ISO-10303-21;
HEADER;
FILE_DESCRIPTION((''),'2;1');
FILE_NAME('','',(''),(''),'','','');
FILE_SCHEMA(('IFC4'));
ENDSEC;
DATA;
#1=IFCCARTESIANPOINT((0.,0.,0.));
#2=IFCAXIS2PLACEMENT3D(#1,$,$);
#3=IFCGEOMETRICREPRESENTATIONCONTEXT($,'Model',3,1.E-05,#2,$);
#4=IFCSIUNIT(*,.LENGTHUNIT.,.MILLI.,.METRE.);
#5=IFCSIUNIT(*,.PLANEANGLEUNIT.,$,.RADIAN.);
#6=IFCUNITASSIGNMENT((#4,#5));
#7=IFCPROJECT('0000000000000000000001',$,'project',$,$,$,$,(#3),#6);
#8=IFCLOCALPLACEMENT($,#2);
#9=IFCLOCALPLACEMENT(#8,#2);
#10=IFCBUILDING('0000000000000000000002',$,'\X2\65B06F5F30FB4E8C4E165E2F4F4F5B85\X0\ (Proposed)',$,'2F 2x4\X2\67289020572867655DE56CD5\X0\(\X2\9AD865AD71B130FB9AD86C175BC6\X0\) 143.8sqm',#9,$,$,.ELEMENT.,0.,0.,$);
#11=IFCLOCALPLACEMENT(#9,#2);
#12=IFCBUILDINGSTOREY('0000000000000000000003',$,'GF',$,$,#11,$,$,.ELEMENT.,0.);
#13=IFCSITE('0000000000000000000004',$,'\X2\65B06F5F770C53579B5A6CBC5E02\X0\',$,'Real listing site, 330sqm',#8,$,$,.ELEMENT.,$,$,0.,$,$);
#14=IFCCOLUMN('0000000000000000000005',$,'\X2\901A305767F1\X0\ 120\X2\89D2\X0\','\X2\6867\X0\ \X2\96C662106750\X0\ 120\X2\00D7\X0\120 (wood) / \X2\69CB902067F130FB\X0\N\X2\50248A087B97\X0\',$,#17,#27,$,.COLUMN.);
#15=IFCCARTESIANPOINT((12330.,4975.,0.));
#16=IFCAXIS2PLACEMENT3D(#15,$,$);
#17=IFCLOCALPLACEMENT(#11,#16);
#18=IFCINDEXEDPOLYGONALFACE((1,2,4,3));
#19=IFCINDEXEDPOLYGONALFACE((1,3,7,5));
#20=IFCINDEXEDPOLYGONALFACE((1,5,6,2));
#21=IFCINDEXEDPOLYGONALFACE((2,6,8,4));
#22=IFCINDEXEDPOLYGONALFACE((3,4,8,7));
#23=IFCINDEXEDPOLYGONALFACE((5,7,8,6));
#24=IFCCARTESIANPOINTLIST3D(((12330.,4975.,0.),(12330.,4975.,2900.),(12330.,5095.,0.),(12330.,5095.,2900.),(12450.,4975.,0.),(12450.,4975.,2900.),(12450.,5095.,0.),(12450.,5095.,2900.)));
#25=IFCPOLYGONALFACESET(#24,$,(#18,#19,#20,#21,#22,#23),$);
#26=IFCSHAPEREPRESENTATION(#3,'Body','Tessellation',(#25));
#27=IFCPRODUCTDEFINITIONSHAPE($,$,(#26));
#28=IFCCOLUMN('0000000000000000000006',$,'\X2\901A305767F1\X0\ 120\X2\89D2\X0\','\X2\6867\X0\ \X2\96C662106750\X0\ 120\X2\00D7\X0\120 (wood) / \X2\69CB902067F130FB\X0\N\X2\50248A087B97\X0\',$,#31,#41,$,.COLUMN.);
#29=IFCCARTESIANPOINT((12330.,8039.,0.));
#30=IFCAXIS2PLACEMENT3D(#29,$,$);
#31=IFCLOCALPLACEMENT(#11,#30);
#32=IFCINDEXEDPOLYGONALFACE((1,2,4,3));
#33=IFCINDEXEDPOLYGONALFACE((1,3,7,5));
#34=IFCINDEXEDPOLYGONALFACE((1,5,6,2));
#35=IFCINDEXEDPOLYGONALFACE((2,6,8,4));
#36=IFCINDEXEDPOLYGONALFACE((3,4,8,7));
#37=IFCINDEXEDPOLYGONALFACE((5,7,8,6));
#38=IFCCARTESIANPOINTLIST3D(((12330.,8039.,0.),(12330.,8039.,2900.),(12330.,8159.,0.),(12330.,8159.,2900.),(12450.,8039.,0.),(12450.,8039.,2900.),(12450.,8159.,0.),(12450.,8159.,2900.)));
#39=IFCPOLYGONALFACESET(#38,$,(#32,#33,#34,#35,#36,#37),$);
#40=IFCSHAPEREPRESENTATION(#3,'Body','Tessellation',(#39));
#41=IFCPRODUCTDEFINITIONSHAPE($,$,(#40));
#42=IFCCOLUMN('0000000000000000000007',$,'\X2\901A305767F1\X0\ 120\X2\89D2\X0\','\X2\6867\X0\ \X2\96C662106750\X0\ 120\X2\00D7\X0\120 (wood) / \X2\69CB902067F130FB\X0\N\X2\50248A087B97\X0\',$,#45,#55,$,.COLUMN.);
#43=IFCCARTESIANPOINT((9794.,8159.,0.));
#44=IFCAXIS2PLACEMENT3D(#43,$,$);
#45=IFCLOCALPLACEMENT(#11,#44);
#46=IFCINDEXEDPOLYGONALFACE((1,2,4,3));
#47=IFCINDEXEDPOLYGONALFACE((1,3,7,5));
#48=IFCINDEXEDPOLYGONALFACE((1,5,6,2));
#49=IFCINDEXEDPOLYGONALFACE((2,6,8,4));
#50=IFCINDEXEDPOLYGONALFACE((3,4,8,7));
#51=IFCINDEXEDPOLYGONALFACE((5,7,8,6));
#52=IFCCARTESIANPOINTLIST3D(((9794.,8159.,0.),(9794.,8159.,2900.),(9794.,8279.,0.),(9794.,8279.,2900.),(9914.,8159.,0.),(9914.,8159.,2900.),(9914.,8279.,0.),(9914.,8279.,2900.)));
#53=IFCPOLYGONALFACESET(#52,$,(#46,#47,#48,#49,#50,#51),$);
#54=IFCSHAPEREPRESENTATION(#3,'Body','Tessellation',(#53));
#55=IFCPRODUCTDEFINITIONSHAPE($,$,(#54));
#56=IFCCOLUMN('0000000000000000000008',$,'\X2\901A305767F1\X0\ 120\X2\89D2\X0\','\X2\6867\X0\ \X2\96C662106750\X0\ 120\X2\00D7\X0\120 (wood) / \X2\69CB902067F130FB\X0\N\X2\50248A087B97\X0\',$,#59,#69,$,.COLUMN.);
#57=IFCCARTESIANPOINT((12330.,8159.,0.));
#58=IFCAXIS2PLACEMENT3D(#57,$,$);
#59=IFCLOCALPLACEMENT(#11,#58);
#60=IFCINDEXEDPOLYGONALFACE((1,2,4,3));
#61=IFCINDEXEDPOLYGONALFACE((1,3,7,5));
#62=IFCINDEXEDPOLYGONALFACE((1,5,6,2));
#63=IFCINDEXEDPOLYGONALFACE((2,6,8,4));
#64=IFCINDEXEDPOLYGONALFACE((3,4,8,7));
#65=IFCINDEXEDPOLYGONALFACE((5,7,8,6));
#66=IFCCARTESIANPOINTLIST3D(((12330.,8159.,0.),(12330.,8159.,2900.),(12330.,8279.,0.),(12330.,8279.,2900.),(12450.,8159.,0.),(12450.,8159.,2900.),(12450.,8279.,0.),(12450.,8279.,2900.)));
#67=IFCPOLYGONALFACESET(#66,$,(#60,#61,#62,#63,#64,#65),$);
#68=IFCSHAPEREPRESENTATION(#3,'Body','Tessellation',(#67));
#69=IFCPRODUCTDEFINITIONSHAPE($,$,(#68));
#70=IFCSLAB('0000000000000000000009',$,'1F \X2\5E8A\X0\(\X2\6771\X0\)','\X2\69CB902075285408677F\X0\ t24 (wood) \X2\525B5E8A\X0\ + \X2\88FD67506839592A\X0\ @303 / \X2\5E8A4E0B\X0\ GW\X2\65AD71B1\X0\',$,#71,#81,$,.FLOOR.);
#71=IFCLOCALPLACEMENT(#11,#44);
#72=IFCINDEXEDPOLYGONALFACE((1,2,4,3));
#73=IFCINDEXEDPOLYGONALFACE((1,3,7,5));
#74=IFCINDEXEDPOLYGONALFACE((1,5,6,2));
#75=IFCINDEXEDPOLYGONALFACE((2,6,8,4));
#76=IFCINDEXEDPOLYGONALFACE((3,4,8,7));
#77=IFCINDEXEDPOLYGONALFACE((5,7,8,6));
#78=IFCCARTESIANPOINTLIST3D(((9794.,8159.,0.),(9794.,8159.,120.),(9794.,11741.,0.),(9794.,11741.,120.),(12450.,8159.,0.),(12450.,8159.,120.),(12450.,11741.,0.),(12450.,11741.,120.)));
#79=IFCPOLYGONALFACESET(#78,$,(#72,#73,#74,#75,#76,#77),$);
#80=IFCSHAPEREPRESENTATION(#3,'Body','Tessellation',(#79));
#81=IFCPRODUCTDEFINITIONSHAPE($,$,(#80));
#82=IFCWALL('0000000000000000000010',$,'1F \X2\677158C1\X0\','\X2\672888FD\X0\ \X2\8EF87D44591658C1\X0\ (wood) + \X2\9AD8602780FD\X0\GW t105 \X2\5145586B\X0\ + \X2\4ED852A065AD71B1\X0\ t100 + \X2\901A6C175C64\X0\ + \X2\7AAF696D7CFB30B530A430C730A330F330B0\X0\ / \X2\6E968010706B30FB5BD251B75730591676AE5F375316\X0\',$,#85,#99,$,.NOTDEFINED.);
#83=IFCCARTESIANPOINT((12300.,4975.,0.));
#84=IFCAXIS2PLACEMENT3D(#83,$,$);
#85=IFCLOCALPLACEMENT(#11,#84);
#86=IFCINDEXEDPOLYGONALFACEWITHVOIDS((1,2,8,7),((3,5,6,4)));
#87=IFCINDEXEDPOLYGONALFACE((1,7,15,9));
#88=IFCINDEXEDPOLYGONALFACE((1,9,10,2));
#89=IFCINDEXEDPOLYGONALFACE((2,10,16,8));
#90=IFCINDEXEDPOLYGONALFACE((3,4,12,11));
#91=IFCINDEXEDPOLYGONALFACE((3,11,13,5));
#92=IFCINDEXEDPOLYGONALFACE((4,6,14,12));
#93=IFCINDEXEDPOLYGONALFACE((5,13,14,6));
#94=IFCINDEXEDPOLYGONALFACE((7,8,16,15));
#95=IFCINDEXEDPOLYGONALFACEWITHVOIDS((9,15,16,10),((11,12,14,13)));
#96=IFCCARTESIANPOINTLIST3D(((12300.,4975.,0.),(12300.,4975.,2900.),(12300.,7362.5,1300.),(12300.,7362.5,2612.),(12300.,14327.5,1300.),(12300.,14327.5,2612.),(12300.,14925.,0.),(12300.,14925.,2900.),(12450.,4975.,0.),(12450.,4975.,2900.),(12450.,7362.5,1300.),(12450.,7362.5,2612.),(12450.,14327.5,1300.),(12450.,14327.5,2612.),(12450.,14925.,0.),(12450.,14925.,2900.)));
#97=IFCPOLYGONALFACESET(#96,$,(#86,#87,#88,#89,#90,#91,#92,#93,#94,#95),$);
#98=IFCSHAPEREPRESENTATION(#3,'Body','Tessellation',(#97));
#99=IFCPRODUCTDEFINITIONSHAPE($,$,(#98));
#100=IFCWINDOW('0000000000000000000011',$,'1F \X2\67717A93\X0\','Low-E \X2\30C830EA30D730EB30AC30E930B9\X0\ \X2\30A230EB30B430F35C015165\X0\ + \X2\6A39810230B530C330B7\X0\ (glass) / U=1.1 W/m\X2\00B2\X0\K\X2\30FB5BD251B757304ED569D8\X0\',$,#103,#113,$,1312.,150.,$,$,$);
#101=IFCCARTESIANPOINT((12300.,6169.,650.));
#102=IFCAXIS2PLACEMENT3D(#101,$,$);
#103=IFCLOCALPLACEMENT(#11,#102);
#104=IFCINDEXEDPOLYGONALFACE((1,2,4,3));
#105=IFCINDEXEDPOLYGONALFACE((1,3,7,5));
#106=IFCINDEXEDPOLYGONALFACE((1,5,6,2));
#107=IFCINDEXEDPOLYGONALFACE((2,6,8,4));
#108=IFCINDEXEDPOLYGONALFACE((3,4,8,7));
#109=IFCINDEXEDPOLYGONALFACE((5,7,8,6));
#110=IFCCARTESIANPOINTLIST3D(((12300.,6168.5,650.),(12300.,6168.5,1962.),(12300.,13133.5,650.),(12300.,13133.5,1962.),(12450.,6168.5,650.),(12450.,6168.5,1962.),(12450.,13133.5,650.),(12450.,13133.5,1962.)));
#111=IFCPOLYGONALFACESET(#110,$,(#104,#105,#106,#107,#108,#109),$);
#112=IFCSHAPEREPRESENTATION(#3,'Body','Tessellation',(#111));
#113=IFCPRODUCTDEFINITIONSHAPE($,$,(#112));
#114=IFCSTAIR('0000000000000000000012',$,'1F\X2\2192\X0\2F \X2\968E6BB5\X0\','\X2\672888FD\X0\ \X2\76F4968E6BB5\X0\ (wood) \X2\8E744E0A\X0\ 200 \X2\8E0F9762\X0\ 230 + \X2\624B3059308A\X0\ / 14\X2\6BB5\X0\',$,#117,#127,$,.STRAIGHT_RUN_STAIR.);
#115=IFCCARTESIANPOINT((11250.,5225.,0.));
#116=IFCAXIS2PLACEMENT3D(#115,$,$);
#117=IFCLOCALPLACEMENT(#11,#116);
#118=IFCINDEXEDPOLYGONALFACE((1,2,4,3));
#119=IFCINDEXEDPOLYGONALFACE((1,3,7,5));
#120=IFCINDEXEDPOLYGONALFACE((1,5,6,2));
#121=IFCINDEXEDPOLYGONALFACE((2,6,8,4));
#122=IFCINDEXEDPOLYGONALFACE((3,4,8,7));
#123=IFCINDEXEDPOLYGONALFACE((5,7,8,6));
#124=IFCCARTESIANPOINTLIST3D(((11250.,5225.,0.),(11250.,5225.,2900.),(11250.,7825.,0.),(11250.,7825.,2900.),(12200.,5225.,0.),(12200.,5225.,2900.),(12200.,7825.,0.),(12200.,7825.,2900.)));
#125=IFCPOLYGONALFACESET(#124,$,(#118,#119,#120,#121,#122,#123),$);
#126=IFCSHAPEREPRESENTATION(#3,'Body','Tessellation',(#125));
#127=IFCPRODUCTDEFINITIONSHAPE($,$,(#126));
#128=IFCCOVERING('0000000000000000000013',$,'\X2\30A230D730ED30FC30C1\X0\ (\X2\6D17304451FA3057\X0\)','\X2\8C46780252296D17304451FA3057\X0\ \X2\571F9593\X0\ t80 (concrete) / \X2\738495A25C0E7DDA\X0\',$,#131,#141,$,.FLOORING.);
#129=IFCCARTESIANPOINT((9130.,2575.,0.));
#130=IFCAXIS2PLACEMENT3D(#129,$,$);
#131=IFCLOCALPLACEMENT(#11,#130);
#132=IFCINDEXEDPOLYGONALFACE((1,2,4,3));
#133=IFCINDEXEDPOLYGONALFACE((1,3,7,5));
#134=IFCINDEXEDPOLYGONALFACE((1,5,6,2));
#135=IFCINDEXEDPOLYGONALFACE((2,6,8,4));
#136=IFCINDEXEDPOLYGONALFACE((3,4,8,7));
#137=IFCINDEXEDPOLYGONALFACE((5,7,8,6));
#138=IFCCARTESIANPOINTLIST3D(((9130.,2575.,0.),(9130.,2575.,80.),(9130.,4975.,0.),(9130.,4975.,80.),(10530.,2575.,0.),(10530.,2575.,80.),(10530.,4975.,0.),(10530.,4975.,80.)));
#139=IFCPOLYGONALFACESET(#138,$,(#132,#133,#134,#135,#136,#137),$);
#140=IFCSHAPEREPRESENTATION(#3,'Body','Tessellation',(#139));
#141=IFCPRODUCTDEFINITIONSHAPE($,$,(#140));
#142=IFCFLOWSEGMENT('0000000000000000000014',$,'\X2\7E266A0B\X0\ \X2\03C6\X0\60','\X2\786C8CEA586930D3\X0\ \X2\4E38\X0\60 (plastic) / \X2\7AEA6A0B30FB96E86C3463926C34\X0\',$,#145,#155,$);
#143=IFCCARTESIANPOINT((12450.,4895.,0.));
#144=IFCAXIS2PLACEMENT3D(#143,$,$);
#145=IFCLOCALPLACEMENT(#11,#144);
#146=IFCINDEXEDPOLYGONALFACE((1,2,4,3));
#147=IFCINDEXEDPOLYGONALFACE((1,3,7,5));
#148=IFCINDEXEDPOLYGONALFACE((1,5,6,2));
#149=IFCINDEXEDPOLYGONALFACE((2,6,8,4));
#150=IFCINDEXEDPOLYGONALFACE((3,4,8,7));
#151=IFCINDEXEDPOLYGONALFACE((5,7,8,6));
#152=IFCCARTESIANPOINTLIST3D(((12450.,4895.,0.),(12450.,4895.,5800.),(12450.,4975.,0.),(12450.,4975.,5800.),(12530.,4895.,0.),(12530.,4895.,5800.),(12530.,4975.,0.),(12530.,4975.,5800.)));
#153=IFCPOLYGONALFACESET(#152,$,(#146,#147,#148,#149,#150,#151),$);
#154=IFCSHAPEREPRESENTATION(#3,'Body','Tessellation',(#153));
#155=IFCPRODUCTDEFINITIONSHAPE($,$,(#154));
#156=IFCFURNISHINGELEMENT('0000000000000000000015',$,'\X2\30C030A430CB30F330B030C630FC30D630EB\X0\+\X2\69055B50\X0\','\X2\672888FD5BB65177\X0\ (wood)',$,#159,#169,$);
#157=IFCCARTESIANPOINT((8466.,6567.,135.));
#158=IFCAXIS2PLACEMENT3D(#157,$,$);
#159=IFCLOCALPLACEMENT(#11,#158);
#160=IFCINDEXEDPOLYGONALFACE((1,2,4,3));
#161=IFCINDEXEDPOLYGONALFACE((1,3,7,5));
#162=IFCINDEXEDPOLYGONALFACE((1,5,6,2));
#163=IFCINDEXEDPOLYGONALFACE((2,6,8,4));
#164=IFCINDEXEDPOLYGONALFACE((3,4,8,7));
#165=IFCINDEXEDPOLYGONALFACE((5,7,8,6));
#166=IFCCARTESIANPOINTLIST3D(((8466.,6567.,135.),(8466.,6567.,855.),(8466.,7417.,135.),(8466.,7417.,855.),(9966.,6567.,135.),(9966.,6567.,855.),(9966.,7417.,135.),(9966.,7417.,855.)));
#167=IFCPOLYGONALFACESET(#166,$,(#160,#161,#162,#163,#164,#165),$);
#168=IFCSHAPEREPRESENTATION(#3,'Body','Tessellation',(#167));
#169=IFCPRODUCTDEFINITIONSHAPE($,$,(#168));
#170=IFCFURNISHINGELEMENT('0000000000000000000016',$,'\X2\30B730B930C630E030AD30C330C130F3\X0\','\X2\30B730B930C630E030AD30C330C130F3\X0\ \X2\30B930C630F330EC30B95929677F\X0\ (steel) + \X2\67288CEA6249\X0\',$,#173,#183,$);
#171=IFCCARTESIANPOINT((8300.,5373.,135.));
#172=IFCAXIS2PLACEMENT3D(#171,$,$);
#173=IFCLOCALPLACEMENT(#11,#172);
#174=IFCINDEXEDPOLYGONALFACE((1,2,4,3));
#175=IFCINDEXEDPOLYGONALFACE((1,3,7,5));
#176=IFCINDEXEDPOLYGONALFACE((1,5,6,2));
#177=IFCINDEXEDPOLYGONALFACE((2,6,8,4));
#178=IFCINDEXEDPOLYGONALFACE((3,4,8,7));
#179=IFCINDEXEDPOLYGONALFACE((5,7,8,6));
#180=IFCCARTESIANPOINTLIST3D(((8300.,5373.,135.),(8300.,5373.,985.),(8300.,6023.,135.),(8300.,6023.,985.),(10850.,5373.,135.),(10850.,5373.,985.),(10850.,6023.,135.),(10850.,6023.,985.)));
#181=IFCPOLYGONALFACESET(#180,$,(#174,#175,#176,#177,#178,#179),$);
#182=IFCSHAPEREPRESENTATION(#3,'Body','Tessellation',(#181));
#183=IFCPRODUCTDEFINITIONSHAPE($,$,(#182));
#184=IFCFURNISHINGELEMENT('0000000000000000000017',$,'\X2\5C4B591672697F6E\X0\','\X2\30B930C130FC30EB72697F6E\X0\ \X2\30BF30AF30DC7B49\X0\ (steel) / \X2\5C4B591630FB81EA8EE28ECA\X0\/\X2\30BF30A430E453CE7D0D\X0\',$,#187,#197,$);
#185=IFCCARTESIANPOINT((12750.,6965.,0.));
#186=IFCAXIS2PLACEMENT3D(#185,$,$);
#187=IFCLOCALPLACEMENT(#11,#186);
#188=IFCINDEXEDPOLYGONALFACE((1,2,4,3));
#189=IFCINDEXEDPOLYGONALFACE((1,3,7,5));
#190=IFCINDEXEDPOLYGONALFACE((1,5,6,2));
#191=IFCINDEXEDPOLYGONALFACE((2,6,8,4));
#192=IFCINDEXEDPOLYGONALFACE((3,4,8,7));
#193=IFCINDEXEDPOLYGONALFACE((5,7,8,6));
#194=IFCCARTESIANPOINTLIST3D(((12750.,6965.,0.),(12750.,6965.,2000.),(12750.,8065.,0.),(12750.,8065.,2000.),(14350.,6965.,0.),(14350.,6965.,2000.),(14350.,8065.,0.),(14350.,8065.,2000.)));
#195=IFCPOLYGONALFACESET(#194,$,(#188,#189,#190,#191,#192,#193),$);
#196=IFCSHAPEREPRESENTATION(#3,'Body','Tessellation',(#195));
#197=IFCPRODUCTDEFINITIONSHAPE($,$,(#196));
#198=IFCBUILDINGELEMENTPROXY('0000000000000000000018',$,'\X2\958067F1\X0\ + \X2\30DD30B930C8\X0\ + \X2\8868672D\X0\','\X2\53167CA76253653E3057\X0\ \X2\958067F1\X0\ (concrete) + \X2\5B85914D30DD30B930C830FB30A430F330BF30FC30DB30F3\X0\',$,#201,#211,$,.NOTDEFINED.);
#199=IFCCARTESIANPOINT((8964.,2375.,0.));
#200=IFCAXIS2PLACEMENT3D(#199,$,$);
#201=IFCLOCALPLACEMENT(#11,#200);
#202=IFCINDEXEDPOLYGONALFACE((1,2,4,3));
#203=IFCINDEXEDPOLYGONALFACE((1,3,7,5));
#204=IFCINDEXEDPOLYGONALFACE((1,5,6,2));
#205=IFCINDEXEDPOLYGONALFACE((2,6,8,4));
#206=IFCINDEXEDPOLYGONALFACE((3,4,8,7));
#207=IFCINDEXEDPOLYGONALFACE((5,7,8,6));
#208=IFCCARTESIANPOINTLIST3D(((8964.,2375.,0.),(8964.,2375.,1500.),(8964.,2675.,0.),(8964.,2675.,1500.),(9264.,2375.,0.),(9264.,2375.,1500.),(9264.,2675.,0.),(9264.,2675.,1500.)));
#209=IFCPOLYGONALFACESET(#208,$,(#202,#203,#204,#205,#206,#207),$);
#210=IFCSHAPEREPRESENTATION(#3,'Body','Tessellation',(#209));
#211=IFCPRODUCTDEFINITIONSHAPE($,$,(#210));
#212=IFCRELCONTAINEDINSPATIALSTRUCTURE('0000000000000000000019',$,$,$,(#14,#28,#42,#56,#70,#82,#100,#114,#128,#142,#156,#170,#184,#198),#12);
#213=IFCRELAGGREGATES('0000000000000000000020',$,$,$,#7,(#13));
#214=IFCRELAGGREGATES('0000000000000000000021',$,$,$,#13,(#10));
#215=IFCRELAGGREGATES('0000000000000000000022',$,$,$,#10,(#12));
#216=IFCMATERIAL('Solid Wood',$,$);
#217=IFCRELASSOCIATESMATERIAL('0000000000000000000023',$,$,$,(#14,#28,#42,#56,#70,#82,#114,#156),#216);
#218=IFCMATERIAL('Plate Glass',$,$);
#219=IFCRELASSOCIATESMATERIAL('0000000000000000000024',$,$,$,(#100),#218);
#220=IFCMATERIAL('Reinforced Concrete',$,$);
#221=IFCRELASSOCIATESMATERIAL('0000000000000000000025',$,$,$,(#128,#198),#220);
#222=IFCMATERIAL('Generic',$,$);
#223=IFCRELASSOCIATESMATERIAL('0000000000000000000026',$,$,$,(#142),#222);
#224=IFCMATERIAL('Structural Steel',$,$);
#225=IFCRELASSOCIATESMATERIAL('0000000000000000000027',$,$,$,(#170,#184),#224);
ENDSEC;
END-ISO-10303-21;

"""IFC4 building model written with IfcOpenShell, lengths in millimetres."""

from ifc_helpers import new_model, si_unit, frame, frame_2d, origin, place, context, project, spatial, rectangle, extrude, material, element, fill, save


model = new_model("IFC4")

# Units and contexts
model_context = context("Model", 3, precision=1e-05, world=origin())
ifc_project = project(units=[si_unit("LENGTHUNIT", "METRE", prefix="MILLI"), si_unit("PLANEANGLEUNIT", "RADIAN")], contexts=[model_context])

# Site, building, storey
site_placement = place(None, origin())
site = spatial("IfcSite", under=ifc_project, at=site_placement, Name="新潟県南魚沼市", ObjectType="Real listing site, 330sqm", CompositionType="ELEMENT", RefElevation=0.0)
building_placement = place(site_placement, origin())
building = spatial("IfcBuilding", under=site, at=building_placement, Name="新潟・二世帯住宅 (Proposed)", ObjectType="2F 2x4木造在来工法(高断熱・高気密) 143.8sqm", CompositionType="ELEMENT", ElevationOfRefHeight=0.0, ElevationOfTerrain=0.0)
storey_placement = place(building_placement, origin())
storey = spatial("IfcBuildingStorey", under=building, at=storey_placement, Name="GF", CompositionType="ELEMENT", Elevation=0.0)

# Columns
ifc_material_1 = material(Name="Solid Wood")
column_1_placement = place(storey_placement, frame((12330.0, 4975.0, 0.0)))
element("IfcColumn", 1, at=column_1_placement, inside=storey, material=ifc_material_1, Name="通し柱 120角", Description="桧 集成材 120×120 (wood) / 構造柱・N値計算", PredefinedType="COLUMN", context=model_context, shape_type="SweptSolid", body=[
    extrude(rectangle(XDim=120.0, YDim=120.0, at=frame_2d((60.0, 60.0))), frame((12330.0, 4975.0, 0.0)), (0.0, 0.0, 1.0), 2900.0),
])
column_2_placement = place(storey_placement, frame((12330.0, 8039.0, 0.0)))
element("IfcColumn", 2, at=column_2_placement, inside=storey, material=ifc_material_1, Name="通し柱 120角", Description="桧 集成材 120×120 (wood) / 構造柱・N値計算", PredefinedType="COLUMN", context=model_context, shape_type="SweptSolid", body=[
    extrude(rectangle(XDim=120.0, YDim=120.0, at=frame_2d((60.0, 60.0))), frame((12330.0, 8039.0, 0.0)), (0.0, 0.0, 1.0), 2900.0),
])
column_3_placement = place(storey_placement, frame((9794.0, 8159.0, 0.0)))
element("IfcColumn", 3, at=column_3_placement, inside=storey, material=ifc_material_1, Name="通し柱 120角", Description="桧 集成材 120×120 (wood) / 構造柱・N値計算", PredefinedType="COLUMN", context=model_context, shape_type="SweptSolid", body=[
    extrude(rectangle(XDim=120.0, YDim=120.0, at=frame_2d((60.0, 60.0))), frame((9794.0, 8159.0, 0.0)), (0.0, 0.0, 1.0), 2900.0),
])
column_4_placement = place(storey_placement, frame((12330.0, 8159.0, 0.0)))
element("IfcColumn", 4, at=column_4_placement, inside=storey, material=ifc_material_1, Name="通し柱 120角", Description="桧 集成材 120×120 (wood) / 構造柱・N値計算", PredefinedType="COLUMN", context=model_context, shape_type="SweptSolid", body=[
    extrude(rectangle(XDim=120.0, YDim=120.0, at=frame_2d((60.0, 60.0))), frame((12330.0, 8159.0, 0.0)), (0.0, 0.0, 1.0), 2900.0),
])

# Slab
slab_placement = place(storey_placement, frame((9794.0, 8159.0, 0.0)))
element("IfcSlab", 5, at=slab_placement, inside=storey, material=ifc_material_1, Name="1F 床(東)", Description="構造用合板 t24 (wood) 剛床 + 製材根太 @303 / 床下 GW断熱", PredefinedType="FLOOR", context=model_context, shape_type="SweptSolid", body=[
    extrude(rectangle(XDim=2656.0, YDim=3582.0, at=frame_2d((1328.0, 1791.0))), frame((9794.0, 8159.0, 0.0)), (0.0, 0.0, 1.0), 120.0),
])

# Wall, opening, window
wall_1_placement = place(storey_placement, frame((12300.0, 4975.0, 0.0)))
wall_1 = element("IfcWall", 6, at=wall_1_placement, inside=storey, material=ifc_material_1, Name="1F 東壁", Description="木製 軸組外壁 (wood) + 高性能GW t105 充填 + 付加断熱 t100 + 通気層 + 窯業系サイディング / 準耐火・寒冷地外皮強化", PredefinedType="NOTDEFINED", context=model_context, shape_type="SweptSolid", body=[
    extrude(rectangle(XDim=150.0, YDim=9950.0, at=frame_2d((75.0, 4975.0))), frame((12300.0, 4975.0, 0.0)), (0.0, 0.0, 1.0), 2900.0),
])
opening_placement = place(storey_placement, frame((12300.0, 6169.0, 650.0)))
opening = element("IfcOpeningElement", 7, at=opening_placement, cuts=wall_1, PredefinedType="NOTDEFINED", context=model_context, shape_type="SweptSolid", body=[
    extrude(rectangle(XDim=150.0, YDim=6965.0, at=frame_2d((75.0, 3482.0))), frame((12300.0, 6169.0, 650.0)), (0.0, 0.0, 1.0), 1312.0),
])
ifc_material_2 = material(Name="Plate Glass")
window_placement = place(storey_placement, frame((12300.0, 6169.0, 650.0)))
window = element("IfcWindow", 8, at=window_placement, inside=storey, material=ifc_material_2, Name="1F 東窓", Description="Low-E トリプルガラス アルゴン封入 + 樹脂サッシ (glass) / U=1.1 W/m²K・寒冷地仕様", OverallHeight=1312.0, OverallWidth=150.0, context=model_context, shape_type="SweptSolid", body=[
    extrude(rectangle(XDim=150.0, YDim=6965.0, at=frame_2d((75.0, 3482.0))), frame((12300.0, 6169.0, 650.0)), (0.0, 0.0, 1.0), 1312.0),
])
fill(opening, window)

# Stair
stair_placement = place(storey_placement, frame((11250.0, 5225.0, 0.0)))
element("IfcStair", 9, at=stair_placement, inside=storey, material=ifc_material_1, Name="1F→2F 階段", Description="木製 直階段 (wood) 蹴上 200 踏面 230 + 手すり / 14段", PredefinedType="STRAIGHT_RUN_STAIR", context=model_context, shape_type="SweptSolid", body=[
    extrude(rectangle(XDim=950.0, YDim=2600.0, at=frame_2d((475.0, 1300.0))), frame((11250.0, 5225.0, 0.0)), (0.0, 0.0, 1.0), 2900.0),
])

# Covering
ifc_material_3 = material(Name="Reinforced Concrete")
covering_placement = place(storey_placement, frame((9130.0, 2575.0, 0.0)))
element("IfcCovering", 10, at=covering_placement, inside=storey, material=ifc_material_3, Name="アプローチ (洗い出し)", Description="豆砂利洗い出し 土間 t80 (concrete) / 玄関導線", PredefinedType="FLOORING", context=model_context, shape_type="SweptSolid", body=[
    extrude(rectangle(XDim=1400.0, YDim=2400.0, at=frame_2d((700.0, 1200.0))), frame((9130.0, 2575.0, 0.0)), (0.0, 0.0, 1.0), 80.0),
])

# Flow segment
ifc_material_4 = material(Name="Generic")
flow_segment_placement = place(storey_placement, frame((12450.0, 4895.0, 0.0)))
element("IfcFlowSegment", 11, at=flow_segment_placement, inside=storey, material=ifc_material_4, Name="縦樋 φ60", Description="硬質塩ビ 丸60 (plastic) / 竪樋・雨水排水", context=model_context, shape_type="SweptSolid", body=[
    extrude(rectangle(XDim=80.0, YDim=80.0, at=frame_2d((40.0, 40.0))), frame((12450.0, 4895.0, 0.0)), (0.0, 0.0, 1.0), 5800.0),
])

# Furnishing elements
furnishing_1_placement = place(storey_placement, frame((8466.0, 6567.0, 135.0)))
element("IfcFurnishingElement", 12, at=furnishing_1_placement, inside=storey, material=ifc_material_1, Name="ダイニングテーブル+椅子", Description="木製家具 (wood)", context=model_context, shape_type="SweptSolid", body=[
    extrude(rectangle(XDim=1500.0, YDim=850.0, at=frame_2d((750.0, 425.0))), frame((8466.0, 6567.0, 135.0)), (0.0, 0.0, 1.0), 720.0),
])
ifc_material_5 = material(Name="Structural Steel")
furnishing_2_placement = place(storey_placement, frame((8300.0, 5373.0, 135.0)))
element("IfcFurnishingElement", 13, at=furnishing_2_placement, inside=storey, material=ifc_material_5, Name="システムキッチン", Description="システムキッチン ステンレス天板 (steel) + 木質扉", context=model_context, shape_type="SweptSolid", body=[
    extrude(rectangle(XDim=2550.0, YDim=650.0, at=frame_2d((1275.0, 325.0))), frame((8300.0, 5373.0, 135.0)), (0.0, 0.0, 1.0), 850.0),
])
furnishing_3_placement = place(storey_placement, frame((12750.0, 6965.0, 0.0)))
element("IfcFurnishingElement", 14, at=furnishing_3_placement, inside=storey, material=ifc_material_5, Name="屋外物置", Description="スチール物置 タクボ等 (steel) / 屋外・自転車/タイヤ収納", context=model_context, shape_type="SweptSolid", body=[
    extrude(rectangle(XDim=1600.0, YDim=1100.0, at=frame_2d((800.0, 550.0))), frame((12750.0, 6965.0, 0.0)), (0.0, 0.0, 1.0), 2000.0),
])

# Building element proxy
proxy_placement = place(storey_placement, frame((8964.0, 2375.0, 0.0)))
element("IfcBuildingElementProxy", 15, at=proxy_placement, inside=storey, material=ifc_material_3, Name="門柱 + ポスト + 表札", Description="化粧打放し 門柱 (concrete) + 宅配ポスト・インターホン", PredefinedType="NOTDEFINED", context=model_context, shape_type="SweptSolid", body=[
    extrude(rectangle(XDim=300.0, YDim=300.0, at=frame_2d((150.0, 150.0))), frame((8964.0, 2375.0, 0.0)), (0.0, 0.0, 1.0), 1500.0),
])

save(model, "model.ifc")
